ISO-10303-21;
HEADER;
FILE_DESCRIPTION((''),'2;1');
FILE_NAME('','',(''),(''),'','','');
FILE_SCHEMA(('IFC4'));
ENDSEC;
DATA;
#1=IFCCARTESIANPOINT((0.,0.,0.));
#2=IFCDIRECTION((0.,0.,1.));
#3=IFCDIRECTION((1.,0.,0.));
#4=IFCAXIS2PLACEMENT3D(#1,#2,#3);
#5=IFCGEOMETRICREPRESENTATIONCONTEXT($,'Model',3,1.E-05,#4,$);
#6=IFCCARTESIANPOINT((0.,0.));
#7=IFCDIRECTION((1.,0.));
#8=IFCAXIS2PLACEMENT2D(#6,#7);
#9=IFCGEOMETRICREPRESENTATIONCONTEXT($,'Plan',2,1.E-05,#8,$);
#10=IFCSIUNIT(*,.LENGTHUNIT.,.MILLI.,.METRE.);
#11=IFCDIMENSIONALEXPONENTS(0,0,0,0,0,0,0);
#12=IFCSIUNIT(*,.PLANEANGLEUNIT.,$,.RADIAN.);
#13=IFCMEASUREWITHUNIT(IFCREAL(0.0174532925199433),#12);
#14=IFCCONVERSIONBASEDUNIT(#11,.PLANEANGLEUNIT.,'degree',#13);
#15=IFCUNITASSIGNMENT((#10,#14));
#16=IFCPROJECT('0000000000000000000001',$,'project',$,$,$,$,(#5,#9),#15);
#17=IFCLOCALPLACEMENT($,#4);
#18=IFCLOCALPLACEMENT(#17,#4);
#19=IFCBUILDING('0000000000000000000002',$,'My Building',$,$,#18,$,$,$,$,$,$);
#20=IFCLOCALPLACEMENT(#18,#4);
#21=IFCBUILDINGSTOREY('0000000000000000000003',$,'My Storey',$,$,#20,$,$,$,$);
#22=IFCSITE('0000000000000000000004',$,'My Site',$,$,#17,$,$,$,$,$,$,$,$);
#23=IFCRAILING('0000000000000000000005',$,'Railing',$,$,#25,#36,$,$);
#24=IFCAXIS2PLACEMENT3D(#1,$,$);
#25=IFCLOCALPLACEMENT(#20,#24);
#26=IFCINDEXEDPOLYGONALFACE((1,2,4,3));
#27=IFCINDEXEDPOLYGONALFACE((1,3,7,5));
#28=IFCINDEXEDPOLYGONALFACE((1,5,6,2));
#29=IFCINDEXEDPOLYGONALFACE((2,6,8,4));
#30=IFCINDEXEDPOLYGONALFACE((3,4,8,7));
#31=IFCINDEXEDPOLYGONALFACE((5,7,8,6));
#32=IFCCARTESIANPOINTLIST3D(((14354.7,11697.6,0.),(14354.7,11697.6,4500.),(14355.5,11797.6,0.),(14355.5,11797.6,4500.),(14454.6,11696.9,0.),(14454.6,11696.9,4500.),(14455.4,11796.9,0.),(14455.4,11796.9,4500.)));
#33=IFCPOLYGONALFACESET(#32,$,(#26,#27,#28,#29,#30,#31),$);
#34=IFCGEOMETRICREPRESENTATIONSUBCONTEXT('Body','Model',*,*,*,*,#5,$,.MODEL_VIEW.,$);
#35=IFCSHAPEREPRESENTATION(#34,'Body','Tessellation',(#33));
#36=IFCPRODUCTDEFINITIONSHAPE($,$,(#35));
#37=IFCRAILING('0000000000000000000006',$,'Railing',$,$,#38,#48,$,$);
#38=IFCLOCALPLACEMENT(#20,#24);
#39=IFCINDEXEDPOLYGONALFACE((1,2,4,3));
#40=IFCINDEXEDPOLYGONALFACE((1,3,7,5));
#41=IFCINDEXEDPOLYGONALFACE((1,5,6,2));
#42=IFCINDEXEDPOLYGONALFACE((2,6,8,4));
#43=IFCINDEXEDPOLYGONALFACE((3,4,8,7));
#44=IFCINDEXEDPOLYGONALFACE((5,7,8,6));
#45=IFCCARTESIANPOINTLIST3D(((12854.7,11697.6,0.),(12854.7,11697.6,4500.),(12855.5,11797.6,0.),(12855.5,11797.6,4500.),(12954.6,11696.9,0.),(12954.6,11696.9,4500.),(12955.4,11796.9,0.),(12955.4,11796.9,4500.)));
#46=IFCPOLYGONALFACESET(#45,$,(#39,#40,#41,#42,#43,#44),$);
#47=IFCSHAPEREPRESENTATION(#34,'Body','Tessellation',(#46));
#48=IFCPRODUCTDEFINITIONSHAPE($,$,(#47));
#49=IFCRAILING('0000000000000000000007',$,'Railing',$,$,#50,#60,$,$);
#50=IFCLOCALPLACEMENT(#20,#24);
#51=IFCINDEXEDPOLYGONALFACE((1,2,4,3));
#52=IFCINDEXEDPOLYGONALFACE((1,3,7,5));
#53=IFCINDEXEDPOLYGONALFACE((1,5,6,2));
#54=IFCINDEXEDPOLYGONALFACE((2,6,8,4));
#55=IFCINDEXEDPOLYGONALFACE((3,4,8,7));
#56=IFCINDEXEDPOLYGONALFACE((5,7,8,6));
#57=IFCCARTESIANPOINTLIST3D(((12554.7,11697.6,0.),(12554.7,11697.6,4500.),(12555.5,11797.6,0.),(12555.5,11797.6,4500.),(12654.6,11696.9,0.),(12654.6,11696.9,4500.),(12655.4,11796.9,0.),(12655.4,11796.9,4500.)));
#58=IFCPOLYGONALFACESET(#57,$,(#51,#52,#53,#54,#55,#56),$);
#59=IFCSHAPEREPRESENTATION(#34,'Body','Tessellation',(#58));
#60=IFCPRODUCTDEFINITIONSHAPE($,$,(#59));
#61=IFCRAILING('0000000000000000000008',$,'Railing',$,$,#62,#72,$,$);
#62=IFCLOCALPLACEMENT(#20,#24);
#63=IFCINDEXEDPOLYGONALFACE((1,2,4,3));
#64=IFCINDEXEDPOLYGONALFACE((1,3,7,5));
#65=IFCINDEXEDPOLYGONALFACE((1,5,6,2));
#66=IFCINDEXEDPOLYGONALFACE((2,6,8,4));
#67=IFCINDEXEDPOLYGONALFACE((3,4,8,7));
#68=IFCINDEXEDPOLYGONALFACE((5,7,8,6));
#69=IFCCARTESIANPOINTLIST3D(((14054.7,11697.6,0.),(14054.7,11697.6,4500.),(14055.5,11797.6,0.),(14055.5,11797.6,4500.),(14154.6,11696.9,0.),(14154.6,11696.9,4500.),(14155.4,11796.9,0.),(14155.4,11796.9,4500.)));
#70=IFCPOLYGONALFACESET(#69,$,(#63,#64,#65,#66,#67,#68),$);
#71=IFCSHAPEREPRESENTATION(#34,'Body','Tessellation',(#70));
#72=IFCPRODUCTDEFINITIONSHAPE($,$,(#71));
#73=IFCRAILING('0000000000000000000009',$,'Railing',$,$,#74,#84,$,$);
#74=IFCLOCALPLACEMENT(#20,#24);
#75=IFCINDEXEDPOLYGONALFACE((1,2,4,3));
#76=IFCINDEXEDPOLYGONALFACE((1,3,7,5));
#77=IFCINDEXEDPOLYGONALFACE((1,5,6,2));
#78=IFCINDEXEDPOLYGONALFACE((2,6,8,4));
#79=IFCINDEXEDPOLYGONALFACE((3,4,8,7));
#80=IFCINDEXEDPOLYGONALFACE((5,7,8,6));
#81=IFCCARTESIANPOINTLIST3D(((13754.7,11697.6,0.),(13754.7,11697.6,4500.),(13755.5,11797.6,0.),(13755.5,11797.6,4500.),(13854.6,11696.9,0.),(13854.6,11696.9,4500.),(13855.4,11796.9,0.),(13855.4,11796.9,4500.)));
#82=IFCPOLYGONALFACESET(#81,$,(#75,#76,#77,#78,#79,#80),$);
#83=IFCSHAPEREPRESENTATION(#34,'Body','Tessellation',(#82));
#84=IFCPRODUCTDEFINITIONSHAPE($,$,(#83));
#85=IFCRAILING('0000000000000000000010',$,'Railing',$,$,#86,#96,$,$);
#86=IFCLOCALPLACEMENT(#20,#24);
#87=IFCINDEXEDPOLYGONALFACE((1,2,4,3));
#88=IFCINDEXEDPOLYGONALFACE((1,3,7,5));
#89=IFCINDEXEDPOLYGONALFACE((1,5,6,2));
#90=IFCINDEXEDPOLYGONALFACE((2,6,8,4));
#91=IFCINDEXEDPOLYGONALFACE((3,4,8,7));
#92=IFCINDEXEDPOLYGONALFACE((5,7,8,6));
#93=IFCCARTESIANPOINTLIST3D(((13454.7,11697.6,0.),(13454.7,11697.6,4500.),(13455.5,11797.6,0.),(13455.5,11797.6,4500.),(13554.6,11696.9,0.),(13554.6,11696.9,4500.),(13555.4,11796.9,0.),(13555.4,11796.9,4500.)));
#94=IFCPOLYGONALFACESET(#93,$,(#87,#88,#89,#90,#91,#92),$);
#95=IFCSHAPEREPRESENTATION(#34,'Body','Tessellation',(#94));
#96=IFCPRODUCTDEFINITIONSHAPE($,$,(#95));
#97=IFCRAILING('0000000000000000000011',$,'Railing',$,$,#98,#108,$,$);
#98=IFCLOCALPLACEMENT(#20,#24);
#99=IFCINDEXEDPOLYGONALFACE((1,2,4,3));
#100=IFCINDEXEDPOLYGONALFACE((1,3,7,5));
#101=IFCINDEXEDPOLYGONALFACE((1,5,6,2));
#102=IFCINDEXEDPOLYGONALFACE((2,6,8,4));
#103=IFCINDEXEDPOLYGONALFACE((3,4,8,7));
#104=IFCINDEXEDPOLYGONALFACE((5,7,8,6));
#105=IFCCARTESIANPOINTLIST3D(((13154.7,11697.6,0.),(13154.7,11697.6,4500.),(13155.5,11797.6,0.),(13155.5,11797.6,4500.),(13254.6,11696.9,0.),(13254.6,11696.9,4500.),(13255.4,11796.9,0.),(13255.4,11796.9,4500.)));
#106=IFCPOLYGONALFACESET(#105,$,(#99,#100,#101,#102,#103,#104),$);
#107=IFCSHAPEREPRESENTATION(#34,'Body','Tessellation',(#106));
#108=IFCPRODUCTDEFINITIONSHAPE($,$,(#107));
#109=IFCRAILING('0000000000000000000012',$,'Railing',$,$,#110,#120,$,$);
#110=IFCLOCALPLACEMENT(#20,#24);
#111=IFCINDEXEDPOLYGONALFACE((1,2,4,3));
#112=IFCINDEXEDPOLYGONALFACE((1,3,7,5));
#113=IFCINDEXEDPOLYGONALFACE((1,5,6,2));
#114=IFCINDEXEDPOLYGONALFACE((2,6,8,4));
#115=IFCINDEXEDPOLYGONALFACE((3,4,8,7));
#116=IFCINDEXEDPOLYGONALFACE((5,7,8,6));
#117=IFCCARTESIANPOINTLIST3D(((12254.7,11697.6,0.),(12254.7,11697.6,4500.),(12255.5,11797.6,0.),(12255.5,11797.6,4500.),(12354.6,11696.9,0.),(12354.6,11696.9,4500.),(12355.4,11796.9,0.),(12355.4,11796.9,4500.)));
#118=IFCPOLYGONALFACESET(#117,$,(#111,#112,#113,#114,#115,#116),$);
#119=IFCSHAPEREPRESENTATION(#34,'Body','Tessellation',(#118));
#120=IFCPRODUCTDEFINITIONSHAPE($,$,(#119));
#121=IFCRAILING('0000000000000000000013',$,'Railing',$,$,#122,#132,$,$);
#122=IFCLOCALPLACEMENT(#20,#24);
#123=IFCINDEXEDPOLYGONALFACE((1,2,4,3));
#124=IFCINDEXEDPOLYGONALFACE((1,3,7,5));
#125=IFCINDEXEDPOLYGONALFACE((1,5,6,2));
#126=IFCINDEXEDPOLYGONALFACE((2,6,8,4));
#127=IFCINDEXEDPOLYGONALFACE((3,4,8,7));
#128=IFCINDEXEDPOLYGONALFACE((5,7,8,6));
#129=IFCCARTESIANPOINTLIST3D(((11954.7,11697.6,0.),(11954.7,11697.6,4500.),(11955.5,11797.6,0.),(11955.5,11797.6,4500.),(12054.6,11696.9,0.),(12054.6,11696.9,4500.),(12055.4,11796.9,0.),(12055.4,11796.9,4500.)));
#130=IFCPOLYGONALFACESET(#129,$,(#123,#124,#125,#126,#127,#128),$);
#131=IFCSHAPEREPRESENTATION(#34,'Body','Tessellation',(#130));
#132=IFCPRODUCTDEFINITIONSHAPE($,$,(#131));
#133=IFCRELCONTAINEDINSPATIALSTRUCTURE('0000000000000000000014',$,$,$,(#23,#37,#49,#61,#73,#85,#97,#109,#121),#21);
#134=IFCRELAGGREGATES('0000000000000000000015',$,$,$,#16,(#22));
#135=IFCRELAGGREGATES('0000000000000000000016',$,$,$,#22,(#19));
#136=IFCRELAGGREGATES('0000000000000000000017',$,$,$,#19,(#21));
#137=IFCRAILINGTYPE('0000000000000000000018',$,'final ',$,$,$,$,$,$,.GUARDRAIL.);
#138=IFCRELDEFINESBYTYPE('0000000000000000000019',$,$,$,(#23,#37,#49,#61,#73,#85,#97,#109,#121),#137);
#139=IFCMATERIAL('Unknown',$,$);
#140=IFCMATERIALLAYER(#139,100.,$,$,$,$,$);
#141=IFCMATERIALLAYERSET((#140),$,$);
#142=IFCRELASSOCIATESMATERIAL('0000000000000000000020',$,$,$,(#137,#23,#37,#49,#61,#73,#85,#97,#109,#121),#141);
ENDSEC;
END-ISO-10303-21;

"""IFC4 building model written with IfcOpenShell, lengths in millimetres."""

from ifc_helpers import new_model, entity, si_unit, converted_unit, frame, origin_with_axes, origin_2d_with_axis, place, context, subcontext, project, spatial, line, indexed_curve, outline, extrude, material, layer, layer_set, layer_usage, type_object, element, save


model = new_model("IFC4")

# Units and contexts
model_context = context("Model", 3, precision=1e-05, world=origin_with_axes())
plan_context = context("Plan", 2, precision=1e-05, world=origin_2d_with_axis())
body_context = subcontext(model_context, "Body", "Model", "MODEL_VIEW")
ifc_project = project(units=[si_unit("LENGTHUNIT", "METRE", prefix="MILLI"), converted_unit("PLANEANGLEUNIT", "degree", entity("IfcReal", 0.0174532925199433), si_unit("PLANEANGLEUNIT", "RADIAN"), dimensions=[0, 0, 0, 0, 0, 0, 0])], contexts=[model_context, plan_context])

# Site, building, storey
site_placement = place(None, origin_with_axes())
site = spatial("IfcSite", under=ifc_project, at=site_placement, Name="My Site")
building_placement = place(site_placement, origin_with_axes())
building = spatial("IfcBuilding", under=site, at=building_placement, Name="My Building")
storey_placement = place(building_placement, origin_with_axes())
storey = spatial("IfcBuildingStorey", under=building, at=storey_placement, Name="My Storey")

# Shared definitions
ifc_material = material(Name="Unknown")

# Railings
ifc_layer_1 = layer(ifc_material, 100.0)
ifc_layer_set_1 = layer_set([ifc_layer_1])
railing_type = type_object("IfcRailingType", Name="final ", PredefinedType="GUARDRAIL", material=ifc_layer_set_1)
ifc_layer_usage_1 = layer_usage(ifc_layer_set_1, "AXIS2", "POSITIVE", 0.0)
railing_1_placement = place(storey_placement, frame((14455.4, 11796.9, 0.0), z_axis=(0.0, 0.0, 1.0), x_axis=(-0.99997, 0.007689, 0.0)))
element("IfcRailing", 1, at=railing_1_placement, inside=storey, type_object=railing_type, material=ifc_layer_usage_1, Name="Railing", context=body_context, shape_type="SweptSolid", body=[
    extrude(outline(indexed_curve([(0.0, 0.0), (0.0, 100.0), (99.8, 100.0), (99.8, 0.0)], segments=[line(1, 2, 3, 4, 1)])), origin_with_axes(), (0.0, 0.0, 1.0), 4500.0),
])
ifc_layer_usage_2 = layer_usage(ifc_layer_set_1, "AXIS2", "POSITIVE", 0.0)
railing_2_placement = place(storey_placement, frame((12955.4, 11796.9, 0.0), z_axis=(0.0, 0.0, 1.0), x_axis=(-0.99997, 0.007689, 0.0)))
element("IfcRailing", 2, at=railing_2_placement, inside=storey, type_object=railing_type, material=ifc_layer_usage_2, Name="Railing", context=body_context, shape_type="SweptSolid", body=[
    extrude(outline(indexed_curve([(0.0, 0.0), (0.0, 100.0), (99.8, 100.0), (99.8, 0.0)], segments=[line(1, 2, 3, 4, 1)])), origin_with_axes(), (0.0, 0.0, 1.0), 4500.0),
])
ifc_layer_usage_3 = layer_usage(ifc_layer_set_1, "AXIS2", "POSITIVE", 0.0)
railing_3_placement = place(storey_placement, frame((12655.4, 11796.9, 0.0), z_axis=(0.0, 0.0, 1.0), x_axis=(-0.99997, 0.007689, 0.0)))
element("IfcRailing", 3, at=railing_3_placement, inside=storey, type_object=railing_type, material=ifc_layer_usage_3, Name="Railing", context=body_context, shape_type="SweptSolid", body=[
    extrude(outline(indexed_curve([(0.0, 0.0), (0.0, 100.0), (99.8, 100.0), (99.8, 0.0)], segments=[line(1, 2, 3, 4, 1)])), origin_with_axes(), (0.0, 0.0, 1.0), 4500.0),
])
ifc_layer_usage_4 = layer_usage(ifc_layer_set_1, "AXIS2", "POSITIVE", 0.0)
railing_4_placement = place(storey_placement, frame((14155.4, 11796.9, 0.0), z_axis=(0.0, 0.0, 1.0), x_axis=(-0.99997, 0.007689, 0.0)))
element("IfcRailing", 4, at=railing_4_placement, inside=storey, type_object=railing_type, material=ifc_layer_usage_4, Name="Railing", context=body_context, shape_type="SweptSolid", body=[
    extrude(outline(indexed_curve([(0.0, 0.0), (0.0, 100.0), (99.8, 100.0), (99.8, 0.0)], segments=[line(1, 2, 3, 4, 1)])), origin_with_axes(), (0.0, 0.0, 1.0), 4500.0),
])
ifc_layer_usage_5 = layer_usage(ifc_layer_set_1, "AXIS2", "POSITIVE", 0.0)
railing_5_placement = place(storey_placement, frame((13855.4, 11796.9, 0.0), z_axis=(0.0, 0.0, 1.0), x_axis=(-0.99997, 0.007689, 0.0)))
element("IfcRailing", 5, at=railing_5_placement, inside=storey, type_object=railing_type, material=ifc_layer_usage_5, Name="Railing", context=body_context, shape_type="SweptSolid", body=[
    extrude(outline(indexed_curve([(0.0, 0.0), (0.0, 100.0), (99.8, 100.0), (99.8, 0.0)], segments=[line(1, 2, 3, 4, 1)])), origin_with_axes(), (0.0, 0.0, 1.0), 4500.0),
])
ifc_layer_usage_6 = layer_usage(ifc_layer_set_1, "AXIS2", "POSITIVE", 0.0)
railing_6_placement = place(storey_placement, frame((13555.4, 11796.9, 0.0), z_axis=(0.0, 0.0, 1.0), x_axis=(-0.99997, 0.007689, 0.0)))
element("IfcRailing", 6, at=railing_6_placement, inside=storey, type_object=railing_type, material=ifc_layer_usage_6, Name="Railing", context=body_context, shape_type="SweptSolid", body=[
    extrude(outline(indexed_curve([(0.0, 0.0), (0.0, 100.0), (99.8, 100.0), (99.8, 0.0)], segments=[line(1, 2, 3, 4, 1)])), origin_with_axes(), (0.0, 0.0, 1.0), 4500.0),
])
ifc_layer_usage_7 = layer_usage(ifc_layer_set_1, "AXIS2", "POSITIVE", 0.0)
railing_7_placement = place(storey_placement, frame((13255.4, 11796.9, 0.0), z_axis=(0.0, 0.0, 1.0), x_axis=(-0.99997, 0.007689, 0.0)))
element("IfcRailing", 7, at=railing_7_placement, inside=storey, type_object=railing_type, material=ifc_layer_usage_7, Name="Railing", context=body_context, shape_type="SweptSolid", body=[
    extrude(outline(indexed_curve([(0.0, 0.0), (0.0, 100.0), (99.8, 100.0), (99.8, 0.0)], segments=[line(1, 2, 3, 4, 1)])), origin_with_axes(), (0.0, 0.0, 1.0), 4500.0),
])
ifc_layer_usage_8 = layer_usage(ifc_layer_set_1, "AXIS2", "POSITIVE", 0.0)
railing_8_placement = place(storey_placement, frame((12355.4, 11796.9, 0.0), z_axis=(0.0, 0.0, 1.0), x_axis=(-0.99997, 0.007689, 0.0)))
element("IfcRailing", 8, at=railing_8_placement, inside=storey, type_object=railing_type, material=ifc_layer_usage_8, Name="Railing", context=body_context, shape_type="SweptSolid", body=[
    extrude(outline(indexed_curve([(0.0, 0.0), (0.0, 100.0), (99.8, 100.0), (99.8, 0.0)], segments=[line(1, 2, 3, 4, 1)])), origin_with_axes(), (0.0, 0.0, 1.0), 4500.0),
])
ifc_layer_usage_9 = layer_usage(ifc_layer_set_1, "AXIS2", "POSITIVE", 0.0)
railing_9_placement = place(storey_placement, frame((12055.4, 11796.9, 0.0), z_axis=(0.0, 0.0, 1.0), x_axis=(-0.99997, 0.007689, 0.0)))
element("IfcRailing", 9, at=railing_9_placement, inside=storey, type_object=railing_type, material=ifc_layer_usage_9, Name="Railing", context=body_context, shape_type="SweptSolid", body=[
    extrude(outline(indexed_curve([(0.0, 0.0), (0.0, 100.0), (99.8, 100.0), (99.8, 0.0)], segments=[line(1, 2, 3, 4, 1)])), origin_with_axes(), (0.0, 0.0, 1.0), 4500.0),
])

save(model, "model.ifc")
